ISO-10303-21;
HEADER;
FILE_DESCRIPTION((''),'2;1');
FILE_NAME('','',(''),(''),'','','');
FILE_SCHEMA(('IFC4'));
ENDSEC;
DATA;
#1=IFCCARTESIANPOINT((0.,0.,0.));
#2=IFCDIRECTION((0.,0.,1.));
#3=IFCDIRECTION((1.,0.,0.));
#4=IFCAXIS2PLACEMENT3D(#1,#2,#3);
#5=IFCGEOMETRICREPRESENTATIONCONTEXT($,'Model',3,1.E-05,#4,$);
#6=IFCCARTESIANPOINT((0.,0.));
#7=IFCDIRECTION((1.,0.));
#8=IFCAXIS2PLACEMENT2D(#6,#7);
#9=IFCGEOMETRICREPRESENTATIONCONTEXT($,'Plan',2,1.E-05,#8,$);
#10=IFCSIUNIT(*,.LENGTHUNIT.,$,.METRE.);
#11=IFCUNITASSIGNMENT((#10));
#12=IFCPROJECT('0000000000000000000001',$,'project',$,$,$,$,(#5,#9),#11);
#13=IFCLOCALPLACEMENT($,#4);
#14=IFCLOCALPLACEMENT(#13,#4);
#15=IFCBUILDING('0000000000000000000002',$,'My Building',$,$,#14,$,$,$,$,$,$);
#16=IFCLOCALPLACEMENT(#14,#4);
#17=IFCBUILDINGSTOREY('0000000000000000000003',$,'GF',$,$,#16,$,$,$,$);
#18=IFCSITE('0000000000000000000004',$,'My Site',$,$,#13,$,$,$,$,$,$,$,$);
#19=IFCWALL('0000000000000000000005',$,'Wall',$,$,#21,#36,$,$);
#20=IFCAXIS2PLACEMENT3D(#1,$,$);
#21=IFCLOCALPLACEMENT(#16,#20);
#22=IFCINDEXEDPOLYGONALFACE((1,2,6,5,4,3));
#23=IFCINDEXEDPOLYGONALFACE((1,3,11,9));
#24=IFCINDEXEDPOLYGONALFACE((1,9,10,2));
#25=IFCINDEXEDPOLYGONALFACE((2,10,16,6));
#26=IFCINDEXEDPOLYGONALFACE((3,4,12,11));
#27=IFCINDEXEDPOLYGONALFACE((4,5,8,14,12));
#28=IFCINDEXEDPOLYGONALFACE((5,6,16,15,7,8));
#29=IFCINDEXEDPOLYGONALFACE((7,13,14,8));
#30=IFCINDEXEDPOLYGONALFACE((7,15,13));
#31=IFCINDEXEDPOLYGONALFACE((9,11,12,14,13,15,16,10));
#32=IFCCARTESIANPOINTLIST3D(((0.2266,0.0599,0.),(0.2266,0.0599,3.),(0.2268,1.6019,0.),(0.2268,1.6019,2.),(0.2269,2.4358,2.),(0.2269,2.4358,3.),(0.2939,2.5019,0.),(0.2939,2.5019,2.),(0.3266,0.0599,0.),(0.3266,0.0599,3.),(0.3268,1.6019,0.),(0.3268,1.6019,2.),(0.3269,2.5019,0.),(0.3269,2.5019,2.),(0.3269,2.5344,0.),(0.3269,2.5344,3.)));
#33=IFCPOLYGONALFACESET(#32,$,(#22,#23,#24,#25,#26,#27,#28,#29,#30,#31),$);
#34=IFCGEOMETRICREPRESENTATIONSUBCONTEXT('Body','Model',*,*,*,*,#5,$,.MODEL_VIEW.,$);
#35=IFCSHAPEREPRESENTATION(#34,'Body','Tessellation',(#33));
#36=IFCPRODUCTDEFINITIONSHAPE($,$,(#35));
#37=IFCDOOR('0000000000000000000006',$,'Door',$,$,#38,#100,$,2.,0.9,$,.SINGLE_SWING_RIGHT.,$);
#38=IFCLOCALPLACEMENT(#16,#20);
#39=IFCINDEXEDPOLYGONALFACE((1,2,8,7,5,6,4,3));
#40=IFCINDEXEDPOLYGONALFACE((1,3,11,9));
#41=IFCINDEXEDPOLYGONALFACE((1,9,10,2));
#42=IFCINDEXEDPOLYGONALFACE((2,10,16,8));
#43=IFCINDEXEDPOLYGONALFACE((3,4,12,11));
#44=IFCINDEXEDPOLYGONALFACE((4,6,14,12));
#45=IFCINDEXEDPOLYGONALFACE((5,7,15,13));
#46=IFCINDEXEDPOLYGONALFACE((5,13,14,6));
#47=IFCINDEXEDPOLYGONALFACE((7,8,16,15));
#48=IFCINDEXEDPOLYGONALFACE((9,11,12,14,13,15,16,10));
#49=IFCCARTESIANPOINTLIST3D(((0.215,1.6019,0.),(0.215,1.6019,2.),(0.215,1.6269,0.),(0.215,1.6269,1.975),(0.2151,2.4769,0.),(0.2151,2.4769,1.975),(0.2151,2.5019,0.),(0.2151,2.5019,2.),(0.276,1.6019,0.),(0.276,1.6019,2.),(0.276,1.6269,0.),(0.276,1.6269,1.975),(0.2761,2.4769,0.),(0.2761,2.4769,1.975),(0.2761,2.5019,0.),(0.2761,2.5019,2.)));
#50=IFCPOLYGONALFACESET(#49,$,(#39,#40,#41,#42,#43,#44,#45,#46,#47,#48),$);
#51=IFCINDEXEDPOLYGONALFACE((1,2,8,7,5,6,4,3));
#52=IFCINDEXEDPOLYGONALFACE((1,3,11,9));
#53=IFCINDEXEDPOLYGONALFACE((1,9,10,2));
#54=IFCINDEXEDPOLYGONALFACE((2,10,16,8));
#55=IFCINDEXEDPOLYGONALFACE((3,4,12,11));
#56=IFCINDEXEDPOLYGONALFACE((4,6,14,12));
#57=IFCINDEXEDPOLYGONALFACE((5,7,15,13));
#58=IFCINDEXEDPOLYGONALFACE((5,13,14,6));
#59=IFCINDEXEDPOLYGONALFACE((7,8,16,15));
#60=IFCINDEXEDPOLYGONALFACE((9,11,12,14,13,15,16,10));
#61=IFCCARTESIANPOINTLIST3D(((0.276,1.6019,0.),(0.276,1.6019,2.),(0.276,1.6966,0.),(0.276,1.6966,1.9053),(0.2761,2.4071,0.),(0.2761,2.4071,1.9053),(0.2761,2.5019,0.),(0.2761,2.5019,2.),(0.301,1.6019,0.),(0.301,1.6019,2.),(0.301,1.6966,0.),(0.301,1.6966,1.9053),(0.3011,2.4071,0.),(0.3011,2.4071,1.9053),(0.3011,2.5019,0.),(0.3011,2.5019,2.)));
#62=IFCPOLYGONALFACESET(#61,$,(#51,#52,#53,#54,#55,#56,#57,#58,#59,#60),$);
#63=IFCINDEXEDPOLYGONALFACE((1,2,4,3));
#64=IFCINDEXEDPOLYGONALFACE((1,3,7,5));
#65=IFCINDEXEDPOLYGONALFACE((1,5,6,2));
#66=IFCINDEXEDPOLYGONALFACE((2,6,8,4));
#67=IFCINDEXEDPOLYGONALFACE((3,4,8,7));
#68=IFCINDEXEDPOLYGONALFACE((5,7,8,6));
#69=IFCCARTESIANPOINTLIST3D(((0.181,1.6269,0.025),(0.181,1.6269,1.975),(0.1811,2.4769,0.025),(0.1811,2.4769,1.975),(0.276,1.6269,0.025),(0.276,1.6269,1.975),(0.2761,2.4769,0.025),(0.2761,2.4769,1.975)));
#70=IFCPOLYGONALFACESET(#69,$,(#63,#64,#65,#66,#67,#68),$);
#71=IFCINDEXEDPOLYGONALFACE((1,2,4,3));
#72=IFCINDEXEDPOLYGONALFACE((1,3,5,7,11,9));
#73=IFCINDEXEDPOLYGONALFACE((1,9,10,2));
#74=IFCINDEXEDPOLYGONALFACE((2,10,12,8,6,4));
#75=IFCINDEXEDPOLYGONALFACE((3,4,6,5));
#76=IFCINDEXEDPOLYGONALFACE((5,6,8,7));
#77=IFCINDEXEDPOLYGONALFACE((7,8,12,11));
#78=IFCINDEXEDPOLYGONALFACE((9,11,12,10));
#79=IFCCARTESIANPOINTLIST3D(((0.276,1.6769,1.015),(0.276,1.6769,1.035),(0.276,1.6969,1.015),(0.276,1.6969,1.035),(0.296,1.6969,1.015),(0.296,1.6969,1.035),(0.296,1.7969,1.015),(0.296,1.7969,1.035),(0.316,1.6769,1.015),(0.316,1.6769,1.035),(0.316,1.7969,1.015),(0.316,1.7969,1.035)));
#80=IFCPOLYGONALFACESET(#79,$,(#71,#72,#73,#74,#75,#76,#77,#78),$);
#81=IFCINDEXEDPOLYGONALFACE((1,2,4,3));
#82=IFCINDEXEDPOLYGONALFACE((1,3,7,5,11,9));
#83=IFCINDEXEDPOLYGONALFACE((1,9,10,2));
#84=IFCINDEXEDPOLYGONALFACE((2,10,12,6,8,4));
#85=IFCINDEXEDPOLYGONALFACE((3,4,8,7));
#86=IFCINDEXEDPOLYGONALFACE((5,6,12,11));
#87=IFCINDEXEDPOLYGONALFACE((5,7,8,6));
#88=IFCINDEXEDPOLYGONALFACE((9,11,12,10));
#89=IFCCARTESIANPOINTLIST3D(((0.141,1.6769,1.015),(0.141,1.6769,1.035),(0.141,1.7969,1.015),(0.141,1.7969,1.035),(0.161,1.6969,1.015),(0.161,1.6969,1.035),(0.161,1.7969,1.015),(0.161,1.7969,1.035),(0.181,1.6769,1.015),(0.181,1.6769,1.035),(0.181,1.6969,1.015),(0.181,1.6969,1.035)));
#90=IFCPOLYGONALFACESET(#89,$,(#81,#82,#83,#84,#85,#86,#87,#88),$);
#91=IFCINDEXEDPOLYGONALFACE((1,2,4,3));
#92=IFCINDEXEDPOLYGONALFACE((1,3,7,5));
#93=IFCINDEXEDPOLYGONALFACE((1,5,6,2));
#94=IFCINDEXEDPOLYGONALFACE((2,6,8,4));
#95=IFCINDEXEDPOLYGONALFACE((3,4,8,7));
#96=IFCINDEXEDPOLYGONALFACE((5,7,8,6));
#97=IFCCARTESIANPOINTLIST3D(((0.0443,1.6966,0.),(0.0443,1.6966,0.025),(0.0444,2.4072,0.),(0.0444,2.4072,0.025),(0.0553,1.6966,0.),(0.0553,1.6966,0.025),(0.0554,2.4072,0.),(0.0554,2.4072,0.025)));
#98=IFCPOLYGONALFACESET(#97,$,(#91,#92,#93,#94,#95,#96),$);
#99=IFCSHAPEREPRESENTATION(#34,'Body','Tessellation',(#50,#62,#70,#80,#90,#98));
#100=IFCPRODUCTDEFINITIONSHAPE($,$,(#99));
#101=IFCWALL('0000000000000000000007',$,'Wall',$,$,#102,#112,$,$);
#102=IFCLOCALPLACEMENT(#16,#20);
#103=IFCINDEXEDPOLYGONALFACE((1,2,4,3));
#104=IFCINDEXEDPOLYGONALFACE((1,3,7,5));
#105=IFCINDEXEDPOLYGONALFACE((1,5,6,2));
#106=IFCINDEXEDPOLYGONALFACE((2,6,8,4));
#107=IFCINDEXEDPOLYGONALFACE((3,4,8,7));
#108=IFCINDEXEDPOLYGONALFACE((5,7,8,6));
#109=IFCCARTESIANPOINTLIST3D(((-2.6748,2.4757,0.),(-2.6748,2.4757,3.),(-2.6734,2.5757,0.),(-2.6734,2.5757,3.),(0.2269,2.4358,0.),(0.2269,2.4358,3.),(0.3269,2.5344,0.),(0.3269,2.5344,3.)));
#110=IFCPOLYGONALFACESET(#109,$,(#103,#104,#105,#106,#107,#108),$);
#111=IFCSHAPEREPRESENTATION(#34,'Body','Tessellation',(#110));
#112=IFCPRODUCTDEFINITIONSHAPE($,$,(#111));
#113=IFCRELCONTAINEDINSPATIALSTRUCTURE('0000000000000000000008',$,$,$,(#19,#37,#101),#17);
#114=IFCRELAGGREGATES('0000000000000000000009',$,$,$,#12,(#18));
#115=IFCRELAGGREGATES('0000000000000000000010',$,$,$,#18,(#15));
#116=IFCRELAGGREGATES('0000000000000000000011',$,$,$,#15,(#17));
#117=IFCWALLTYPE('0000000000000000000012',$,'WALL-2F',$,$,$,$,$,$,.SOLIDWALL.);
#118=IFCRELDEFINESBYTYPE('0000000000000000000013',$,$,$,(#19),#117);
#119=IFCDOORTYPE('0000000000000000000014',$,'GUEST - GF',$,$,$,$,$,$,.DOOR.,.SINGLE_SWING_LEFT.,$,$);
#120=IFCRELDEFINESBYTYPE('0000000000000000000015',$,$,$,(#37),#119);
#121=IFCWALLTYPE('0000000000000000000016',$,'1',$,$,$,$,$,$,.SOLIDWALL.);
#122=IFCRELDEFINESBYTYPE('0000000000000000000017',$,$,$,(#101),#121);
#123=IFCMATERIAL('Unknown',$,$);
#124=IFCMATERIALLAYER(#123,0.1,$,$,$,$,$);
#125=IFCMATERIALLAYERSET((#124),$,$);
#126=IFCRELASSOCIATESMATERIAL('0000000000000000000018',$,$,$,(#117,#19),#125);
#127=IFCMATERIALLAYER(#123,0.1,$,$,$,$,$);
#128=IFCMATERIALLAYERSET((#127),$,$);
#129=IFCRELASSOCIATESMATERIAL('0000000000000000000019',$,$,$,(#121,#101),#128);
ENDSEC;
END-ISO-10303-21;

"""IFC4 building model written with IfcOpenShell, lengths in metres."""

from ifc_helpers import new_model, entity, si_unit, frame, origin_with_axes, origin_2d_with_axis, place, context, subcontext, project, spatial, line, indexed_curve, outline, extrude, shape, source, transform, mapped, material, layer, layer_set, layer_usage, type_object, type_shapes, element, fill, save


model = new_model("IFC4")

# Units and contexts
model_context = context("Model", 3, precision=1e-05, world=origin_with_axes())
plan_context = context("Plan", 2, precision=1e-05, world=origin_2d_with_axis())
body_context_1 = subcontext(model_context, "Body", "Model", "MODEL_VIEW")
body_context_2 = subcontext(plan_context, "Body", "Plan", "PLAN_VIEW")
ifc_project = project(units=[si_unit("LENGTHUNIT", "METRE")], contexts=[model_context, plan_context])

# Site, building, storey
site_placement = place(None, origin_with_axes())
site = spatial("IfcSite", under=ifc_project, at=site_placement, Name="My Site")
building_placement = place(site_placement, origin_with_axes())
building = spatial("IfcBuilding", under=site, at=building_placement, Name="My Building")
storey_placement = place(building_placement, origin_with_axes())
storey = spatial("IfcBuildingStorey", under=building, at=storey_placement, Name="GF")

# Shared definitions
ifc_material_1 = material(Name="Unknown")

# Shared definitions
ifc_layer_1 = layer(ifc_material_1, 0.1)
ifc_layer_set_1 = layer_set([ifc_layer_1])
wall_type_1 = type_object("IfcWallType", Name="WALL-2F", PredefinedType="SOLIDWALL", material=ifc_layer_set_1)

# Wall, opening, door
ifc_layer_usage_1 = layer_usage(ifc_layer_set_1, "AXIS2", "POSITIVE", 0.0)
wall_1_placement = place(storey_placement, frame((0.2269, 2.5358, 0.0), z_axis=(0.0, 0.0, 1.0), x_axis=(-0.000105, -1.0, 0.0)))
wall_1 = element("IfcWall", 1, at=wall_1_placement, inside=storey, type_object=wall_type_1, material=ifc_layer_usage_1, Name="Wall", context=body_context_1, shape_type="SweptSolid", body=[
    extrude(outline(indexed_curve([(0.1, 0.0), (0.0014, 0.1), (2.4759, 0.1), (2.4759, 0.0)], segments=[line(1, 2, 3, 4, 1)])), origin_with_axes(), (0.0, 0.0, 1.0), 3.0),
])
shared_shape_1 = source(origin_with_axes(), body_context_1, "Body", "SweptSolid", [
    extrude(outline(indexed_curve([(0.0, 0.0), (0.9, 0.0), (0.9, 2.0), (0.0, 2.0)], segments=[line(1, 2, 3, 4, 1)])), frame((0.0, -0.6, 0.0), z_axis=(0.0, -1.0, 0.0), x_axis=(1.0, 0.0, 0.0)), (0.0, 0.0, -1.0), 1.2),
])
opening_1_placement = place(wall_1_placement, frame((0.9339, 0.2103, 0.0), z_axis=(0.0, 0.0, 1.0), x_axis=(-1.0, 0.0, 0.0)))
opening_1 = element("IfcOpeningElement", 2, at=opening_1_placement, cuts=wall_1, PredefinedType="OPENING", context=body_context_1, shape_type="MappedRepresentation", body=[
    mapped(shared_shape_1, transform((0.0, 0.0, 0.0), x_axis=(1.0, 0.0, 0.0), y_axis=(0.0, 1.0, 0.0), z_axis=(0.0, 0.0, 1.0), scale=1.0)),
])
door_type_1 = type_object("IfcDoorType", Name="GUEST - GF", OperationType="SINGLE_SWING_LEFT", PredefinedType="DOOR")
shared_shape_2 = source(origin_with_axes(), body_context_1, "Body", "SweptSolid", [
    extrude(outline(indexed_curve([(0.0, 0.0), (0.0, 2.0), (0.9, 2.0), (0.9, 0.0), (0.875, 0.0), (0.875, 1.975), (0.025, 1.975), (0.025, 0.0)], segments=[line(1, 2, 3, 4, 5, 6, 7, 8, 1)])), frame((0.0, 0.0093, 0.0), z_axis=(0.0, -1.0, 0.0), x_axis=(1.0, 0.0, 0.0)), (0.0, 0.0, -1.0), 0.061),
    extrude(outline(indexed_curve([(0.0, 0.0), (0.0, 2.0), (0.9, 2.0), (0.9, 0.0), (0.8053, 0.0), (0.8053, 1.9053), (0.0947, 1.9053), (0.0947, 0.0)], segments=[line(1, 2, 3, 4, 5, 6, 7, 8, 1)])), frame((0.0, -0.0157, 0.0), z_axis=(0.0, -1.0, 0.0), x_axis=(1.0, 0.0, 0.0)), (0.0, 0.0, -1.0), 0.025),
    extrude(outline(indexed_curve([(0.0, 0.0), (0.85, 0.0), (0.85, 0.095), (0.0, 0.095)], segments=[line(1, 2, 3, 4, 1)])), frame((0.025, 0.0093, 0.025), z_axis=(0.0, 0.0, 1.0), x_axis=(1.0, 0.0, 0.0)), (0.0, 0.0, 1.0), 1.95),
    extrude(outline(indexed_curve([(0.0, 0.0), (0.0, -0.04), (0.12, -0.04), (0.12, -0.02), (0.02, -0.02), (0.02, 0.0)], segments=[line(1, 2, 3, 4, 5, 6, 1)])), frame((0.075, 0.0093, 1.015), z_axis=(0.0, 0.0, 1.0), x_axis=(1.0, 0.0, 0.0)), (0.0, 0.0, 1.0), 0.02),
    extrude(outline(indexed_curve([(0.0, 0.0), (0.0, 0.04), (0.12, 0.04), (0.12, 0.02), (0.02, 0.02), (0.02, 0.0)], segments=[line(1, 2, 3, 4, 5, 6, 1)])), frame((0.075, 0.1043, 1.015), z_axis=(0.0, 0.0, 1.0), x_axis=(1.0, 0.0, 0.0)), (0.0, 0.0, 1.0), 0.02),
    extrude(outline(indexed_curve([(0.0, 0.0), (0.7105, 0.0), (0.7105, 0.011), (0.0, 0.011)], segments=[line(1, 2, 3, 4, 1)])), frame((0.0947, 0.23, 0.0), z_axis=(0.0, 0.0, 1.0), x_axis=(1.0, 0.0, 0.0)), (0.0, 0.0, 1.0), 0.025),
])
shared_shape_3 = source(origin_with_axes(), body_context_2, "Body", "Curve2D", [
    entity("IfcIndexedPolyCurve", entity("IfcCartesianPointList2D", [[0.0, -0.0157], [0.0, 0.0703], [0.025, 0.0703], [0.025, 0.0093], [0.0947, 0.0093], [0.0947, -0.0157]]), [entity("IfcLineIndex", [1, 2, 3, 4, 5, 6, 1])]),
    entity("IfcIndexedPolyCurve", entity("IfcCartesianPointList2D", [[0.9, -0.0157], [0.9, 0.0703], [0.875, 0.0703], [0.875, 0.0093], [0.8053, 0.0093], [0.8053, -0.0157]]), [entity("IfcLineIndex", [1, 2, 3, 4, 5, 6, 1])]),
    entity("IfcTrimmedCurve", entity("IfcEllipse", entity("IfcAxis2Placement2D", entity("IfcCartesianPoint", [0.78, 0.0703]), entity("IfcDirection", [1.0, 0.0])), 0.755, 0.85), [entity("IfcCartesianPoint", [0.78, 0.9203])], [entity("IfcCartesianPoint", [0.025, 0.0703])], True, "CARTESIAN"),
    entity("IfcIndexedPolyCurve", entity("IfcCartesianPointList2D", [[0.875, 0.0703], [0.78, 0.0703], [0.78, 0.9203], [0.875, 0.9203]]), [entity("IfcLineIndex", [1, 2, 3, 4, 1])]),
])
type_shapes(door_type_1, [shared_shape_2, shared_shape_3])
door_1_placement = place(opening_1_placement, frame((0.0, 0.1518, 0.0), z_axis=(0.0, 0.0, 1.0), x_axis=(1.0, 0.0, 0.0)))
door_1 = element("IfcDoor", 3, at=door_1_placement, inside=storey, type_object=door_type_1, Name="Door", OperationType="SINGLE_SWING_RIGHT", OverallHeight=2.0, OverallWidth=0.9, shapes=[
    shape(body_context_1, "Body", "MappedRepresentation", [mapped(shared_shape_2, transform((0.0, 0.0, 0.0), x_axis=(1.0, 0.0, 0.0), y_axis=(0.0, 1.0, 0.0), z_axis=(0.0, 0.0, 1.0), scale=1.0))]),
    shape(body_context_2, "Body", "MappedRepresentation", [mapped(shared_shape_3, transform((0.0, 0.0, 0.0), x_axis=(1.0, 0.0, 0.0), y_axis=(0.0, 1.0, 0.0), z_axis=(0.0, 0.0, 1.0), scale=1.0))]),
])
fill(opening_1, door_1)

# Wall
ifc_layer_2 = layer(ifc_material_1, 0.1)
ifc_layer_set_2 = layer_set([ifc_layer_2])
ifc_layer_usage_2 = layer_usage(ifc_layer_set_2, "AXIS2", "POSITIVE", 0.0)
wall_type_2 = type_object("IfcWallType", Name="1", PredefinedType="SOLIDWALL", material=ifc_layer_set_2)
wall_2_placement = place(storey_placement, frame((0.2269, 2.5358, 0.0), z_axis=(0.0, 0.0, 1.0), x_axis=(-0.999905, 0.013761, 0.0)))
element("IfcWall", 4, at=wall_2_placement, inside=storey, type_object=wall_type_2, material=ifc_layer_usage_2, Name="Wall", context=body_context_1, shape_type="SweptSolid", body=[
    extrude(outline(indexed_curve([(-0.1, 0.0), (-0.0014, 0.1), (2.9005, 0.1), (2.9005, 0.0)], segments=[line(1, 2, 3, 4, 1)])), origin_with_axes(), (0.0, 0.0, 1.0), 3.0),
])

save(model, "model.ifc")
